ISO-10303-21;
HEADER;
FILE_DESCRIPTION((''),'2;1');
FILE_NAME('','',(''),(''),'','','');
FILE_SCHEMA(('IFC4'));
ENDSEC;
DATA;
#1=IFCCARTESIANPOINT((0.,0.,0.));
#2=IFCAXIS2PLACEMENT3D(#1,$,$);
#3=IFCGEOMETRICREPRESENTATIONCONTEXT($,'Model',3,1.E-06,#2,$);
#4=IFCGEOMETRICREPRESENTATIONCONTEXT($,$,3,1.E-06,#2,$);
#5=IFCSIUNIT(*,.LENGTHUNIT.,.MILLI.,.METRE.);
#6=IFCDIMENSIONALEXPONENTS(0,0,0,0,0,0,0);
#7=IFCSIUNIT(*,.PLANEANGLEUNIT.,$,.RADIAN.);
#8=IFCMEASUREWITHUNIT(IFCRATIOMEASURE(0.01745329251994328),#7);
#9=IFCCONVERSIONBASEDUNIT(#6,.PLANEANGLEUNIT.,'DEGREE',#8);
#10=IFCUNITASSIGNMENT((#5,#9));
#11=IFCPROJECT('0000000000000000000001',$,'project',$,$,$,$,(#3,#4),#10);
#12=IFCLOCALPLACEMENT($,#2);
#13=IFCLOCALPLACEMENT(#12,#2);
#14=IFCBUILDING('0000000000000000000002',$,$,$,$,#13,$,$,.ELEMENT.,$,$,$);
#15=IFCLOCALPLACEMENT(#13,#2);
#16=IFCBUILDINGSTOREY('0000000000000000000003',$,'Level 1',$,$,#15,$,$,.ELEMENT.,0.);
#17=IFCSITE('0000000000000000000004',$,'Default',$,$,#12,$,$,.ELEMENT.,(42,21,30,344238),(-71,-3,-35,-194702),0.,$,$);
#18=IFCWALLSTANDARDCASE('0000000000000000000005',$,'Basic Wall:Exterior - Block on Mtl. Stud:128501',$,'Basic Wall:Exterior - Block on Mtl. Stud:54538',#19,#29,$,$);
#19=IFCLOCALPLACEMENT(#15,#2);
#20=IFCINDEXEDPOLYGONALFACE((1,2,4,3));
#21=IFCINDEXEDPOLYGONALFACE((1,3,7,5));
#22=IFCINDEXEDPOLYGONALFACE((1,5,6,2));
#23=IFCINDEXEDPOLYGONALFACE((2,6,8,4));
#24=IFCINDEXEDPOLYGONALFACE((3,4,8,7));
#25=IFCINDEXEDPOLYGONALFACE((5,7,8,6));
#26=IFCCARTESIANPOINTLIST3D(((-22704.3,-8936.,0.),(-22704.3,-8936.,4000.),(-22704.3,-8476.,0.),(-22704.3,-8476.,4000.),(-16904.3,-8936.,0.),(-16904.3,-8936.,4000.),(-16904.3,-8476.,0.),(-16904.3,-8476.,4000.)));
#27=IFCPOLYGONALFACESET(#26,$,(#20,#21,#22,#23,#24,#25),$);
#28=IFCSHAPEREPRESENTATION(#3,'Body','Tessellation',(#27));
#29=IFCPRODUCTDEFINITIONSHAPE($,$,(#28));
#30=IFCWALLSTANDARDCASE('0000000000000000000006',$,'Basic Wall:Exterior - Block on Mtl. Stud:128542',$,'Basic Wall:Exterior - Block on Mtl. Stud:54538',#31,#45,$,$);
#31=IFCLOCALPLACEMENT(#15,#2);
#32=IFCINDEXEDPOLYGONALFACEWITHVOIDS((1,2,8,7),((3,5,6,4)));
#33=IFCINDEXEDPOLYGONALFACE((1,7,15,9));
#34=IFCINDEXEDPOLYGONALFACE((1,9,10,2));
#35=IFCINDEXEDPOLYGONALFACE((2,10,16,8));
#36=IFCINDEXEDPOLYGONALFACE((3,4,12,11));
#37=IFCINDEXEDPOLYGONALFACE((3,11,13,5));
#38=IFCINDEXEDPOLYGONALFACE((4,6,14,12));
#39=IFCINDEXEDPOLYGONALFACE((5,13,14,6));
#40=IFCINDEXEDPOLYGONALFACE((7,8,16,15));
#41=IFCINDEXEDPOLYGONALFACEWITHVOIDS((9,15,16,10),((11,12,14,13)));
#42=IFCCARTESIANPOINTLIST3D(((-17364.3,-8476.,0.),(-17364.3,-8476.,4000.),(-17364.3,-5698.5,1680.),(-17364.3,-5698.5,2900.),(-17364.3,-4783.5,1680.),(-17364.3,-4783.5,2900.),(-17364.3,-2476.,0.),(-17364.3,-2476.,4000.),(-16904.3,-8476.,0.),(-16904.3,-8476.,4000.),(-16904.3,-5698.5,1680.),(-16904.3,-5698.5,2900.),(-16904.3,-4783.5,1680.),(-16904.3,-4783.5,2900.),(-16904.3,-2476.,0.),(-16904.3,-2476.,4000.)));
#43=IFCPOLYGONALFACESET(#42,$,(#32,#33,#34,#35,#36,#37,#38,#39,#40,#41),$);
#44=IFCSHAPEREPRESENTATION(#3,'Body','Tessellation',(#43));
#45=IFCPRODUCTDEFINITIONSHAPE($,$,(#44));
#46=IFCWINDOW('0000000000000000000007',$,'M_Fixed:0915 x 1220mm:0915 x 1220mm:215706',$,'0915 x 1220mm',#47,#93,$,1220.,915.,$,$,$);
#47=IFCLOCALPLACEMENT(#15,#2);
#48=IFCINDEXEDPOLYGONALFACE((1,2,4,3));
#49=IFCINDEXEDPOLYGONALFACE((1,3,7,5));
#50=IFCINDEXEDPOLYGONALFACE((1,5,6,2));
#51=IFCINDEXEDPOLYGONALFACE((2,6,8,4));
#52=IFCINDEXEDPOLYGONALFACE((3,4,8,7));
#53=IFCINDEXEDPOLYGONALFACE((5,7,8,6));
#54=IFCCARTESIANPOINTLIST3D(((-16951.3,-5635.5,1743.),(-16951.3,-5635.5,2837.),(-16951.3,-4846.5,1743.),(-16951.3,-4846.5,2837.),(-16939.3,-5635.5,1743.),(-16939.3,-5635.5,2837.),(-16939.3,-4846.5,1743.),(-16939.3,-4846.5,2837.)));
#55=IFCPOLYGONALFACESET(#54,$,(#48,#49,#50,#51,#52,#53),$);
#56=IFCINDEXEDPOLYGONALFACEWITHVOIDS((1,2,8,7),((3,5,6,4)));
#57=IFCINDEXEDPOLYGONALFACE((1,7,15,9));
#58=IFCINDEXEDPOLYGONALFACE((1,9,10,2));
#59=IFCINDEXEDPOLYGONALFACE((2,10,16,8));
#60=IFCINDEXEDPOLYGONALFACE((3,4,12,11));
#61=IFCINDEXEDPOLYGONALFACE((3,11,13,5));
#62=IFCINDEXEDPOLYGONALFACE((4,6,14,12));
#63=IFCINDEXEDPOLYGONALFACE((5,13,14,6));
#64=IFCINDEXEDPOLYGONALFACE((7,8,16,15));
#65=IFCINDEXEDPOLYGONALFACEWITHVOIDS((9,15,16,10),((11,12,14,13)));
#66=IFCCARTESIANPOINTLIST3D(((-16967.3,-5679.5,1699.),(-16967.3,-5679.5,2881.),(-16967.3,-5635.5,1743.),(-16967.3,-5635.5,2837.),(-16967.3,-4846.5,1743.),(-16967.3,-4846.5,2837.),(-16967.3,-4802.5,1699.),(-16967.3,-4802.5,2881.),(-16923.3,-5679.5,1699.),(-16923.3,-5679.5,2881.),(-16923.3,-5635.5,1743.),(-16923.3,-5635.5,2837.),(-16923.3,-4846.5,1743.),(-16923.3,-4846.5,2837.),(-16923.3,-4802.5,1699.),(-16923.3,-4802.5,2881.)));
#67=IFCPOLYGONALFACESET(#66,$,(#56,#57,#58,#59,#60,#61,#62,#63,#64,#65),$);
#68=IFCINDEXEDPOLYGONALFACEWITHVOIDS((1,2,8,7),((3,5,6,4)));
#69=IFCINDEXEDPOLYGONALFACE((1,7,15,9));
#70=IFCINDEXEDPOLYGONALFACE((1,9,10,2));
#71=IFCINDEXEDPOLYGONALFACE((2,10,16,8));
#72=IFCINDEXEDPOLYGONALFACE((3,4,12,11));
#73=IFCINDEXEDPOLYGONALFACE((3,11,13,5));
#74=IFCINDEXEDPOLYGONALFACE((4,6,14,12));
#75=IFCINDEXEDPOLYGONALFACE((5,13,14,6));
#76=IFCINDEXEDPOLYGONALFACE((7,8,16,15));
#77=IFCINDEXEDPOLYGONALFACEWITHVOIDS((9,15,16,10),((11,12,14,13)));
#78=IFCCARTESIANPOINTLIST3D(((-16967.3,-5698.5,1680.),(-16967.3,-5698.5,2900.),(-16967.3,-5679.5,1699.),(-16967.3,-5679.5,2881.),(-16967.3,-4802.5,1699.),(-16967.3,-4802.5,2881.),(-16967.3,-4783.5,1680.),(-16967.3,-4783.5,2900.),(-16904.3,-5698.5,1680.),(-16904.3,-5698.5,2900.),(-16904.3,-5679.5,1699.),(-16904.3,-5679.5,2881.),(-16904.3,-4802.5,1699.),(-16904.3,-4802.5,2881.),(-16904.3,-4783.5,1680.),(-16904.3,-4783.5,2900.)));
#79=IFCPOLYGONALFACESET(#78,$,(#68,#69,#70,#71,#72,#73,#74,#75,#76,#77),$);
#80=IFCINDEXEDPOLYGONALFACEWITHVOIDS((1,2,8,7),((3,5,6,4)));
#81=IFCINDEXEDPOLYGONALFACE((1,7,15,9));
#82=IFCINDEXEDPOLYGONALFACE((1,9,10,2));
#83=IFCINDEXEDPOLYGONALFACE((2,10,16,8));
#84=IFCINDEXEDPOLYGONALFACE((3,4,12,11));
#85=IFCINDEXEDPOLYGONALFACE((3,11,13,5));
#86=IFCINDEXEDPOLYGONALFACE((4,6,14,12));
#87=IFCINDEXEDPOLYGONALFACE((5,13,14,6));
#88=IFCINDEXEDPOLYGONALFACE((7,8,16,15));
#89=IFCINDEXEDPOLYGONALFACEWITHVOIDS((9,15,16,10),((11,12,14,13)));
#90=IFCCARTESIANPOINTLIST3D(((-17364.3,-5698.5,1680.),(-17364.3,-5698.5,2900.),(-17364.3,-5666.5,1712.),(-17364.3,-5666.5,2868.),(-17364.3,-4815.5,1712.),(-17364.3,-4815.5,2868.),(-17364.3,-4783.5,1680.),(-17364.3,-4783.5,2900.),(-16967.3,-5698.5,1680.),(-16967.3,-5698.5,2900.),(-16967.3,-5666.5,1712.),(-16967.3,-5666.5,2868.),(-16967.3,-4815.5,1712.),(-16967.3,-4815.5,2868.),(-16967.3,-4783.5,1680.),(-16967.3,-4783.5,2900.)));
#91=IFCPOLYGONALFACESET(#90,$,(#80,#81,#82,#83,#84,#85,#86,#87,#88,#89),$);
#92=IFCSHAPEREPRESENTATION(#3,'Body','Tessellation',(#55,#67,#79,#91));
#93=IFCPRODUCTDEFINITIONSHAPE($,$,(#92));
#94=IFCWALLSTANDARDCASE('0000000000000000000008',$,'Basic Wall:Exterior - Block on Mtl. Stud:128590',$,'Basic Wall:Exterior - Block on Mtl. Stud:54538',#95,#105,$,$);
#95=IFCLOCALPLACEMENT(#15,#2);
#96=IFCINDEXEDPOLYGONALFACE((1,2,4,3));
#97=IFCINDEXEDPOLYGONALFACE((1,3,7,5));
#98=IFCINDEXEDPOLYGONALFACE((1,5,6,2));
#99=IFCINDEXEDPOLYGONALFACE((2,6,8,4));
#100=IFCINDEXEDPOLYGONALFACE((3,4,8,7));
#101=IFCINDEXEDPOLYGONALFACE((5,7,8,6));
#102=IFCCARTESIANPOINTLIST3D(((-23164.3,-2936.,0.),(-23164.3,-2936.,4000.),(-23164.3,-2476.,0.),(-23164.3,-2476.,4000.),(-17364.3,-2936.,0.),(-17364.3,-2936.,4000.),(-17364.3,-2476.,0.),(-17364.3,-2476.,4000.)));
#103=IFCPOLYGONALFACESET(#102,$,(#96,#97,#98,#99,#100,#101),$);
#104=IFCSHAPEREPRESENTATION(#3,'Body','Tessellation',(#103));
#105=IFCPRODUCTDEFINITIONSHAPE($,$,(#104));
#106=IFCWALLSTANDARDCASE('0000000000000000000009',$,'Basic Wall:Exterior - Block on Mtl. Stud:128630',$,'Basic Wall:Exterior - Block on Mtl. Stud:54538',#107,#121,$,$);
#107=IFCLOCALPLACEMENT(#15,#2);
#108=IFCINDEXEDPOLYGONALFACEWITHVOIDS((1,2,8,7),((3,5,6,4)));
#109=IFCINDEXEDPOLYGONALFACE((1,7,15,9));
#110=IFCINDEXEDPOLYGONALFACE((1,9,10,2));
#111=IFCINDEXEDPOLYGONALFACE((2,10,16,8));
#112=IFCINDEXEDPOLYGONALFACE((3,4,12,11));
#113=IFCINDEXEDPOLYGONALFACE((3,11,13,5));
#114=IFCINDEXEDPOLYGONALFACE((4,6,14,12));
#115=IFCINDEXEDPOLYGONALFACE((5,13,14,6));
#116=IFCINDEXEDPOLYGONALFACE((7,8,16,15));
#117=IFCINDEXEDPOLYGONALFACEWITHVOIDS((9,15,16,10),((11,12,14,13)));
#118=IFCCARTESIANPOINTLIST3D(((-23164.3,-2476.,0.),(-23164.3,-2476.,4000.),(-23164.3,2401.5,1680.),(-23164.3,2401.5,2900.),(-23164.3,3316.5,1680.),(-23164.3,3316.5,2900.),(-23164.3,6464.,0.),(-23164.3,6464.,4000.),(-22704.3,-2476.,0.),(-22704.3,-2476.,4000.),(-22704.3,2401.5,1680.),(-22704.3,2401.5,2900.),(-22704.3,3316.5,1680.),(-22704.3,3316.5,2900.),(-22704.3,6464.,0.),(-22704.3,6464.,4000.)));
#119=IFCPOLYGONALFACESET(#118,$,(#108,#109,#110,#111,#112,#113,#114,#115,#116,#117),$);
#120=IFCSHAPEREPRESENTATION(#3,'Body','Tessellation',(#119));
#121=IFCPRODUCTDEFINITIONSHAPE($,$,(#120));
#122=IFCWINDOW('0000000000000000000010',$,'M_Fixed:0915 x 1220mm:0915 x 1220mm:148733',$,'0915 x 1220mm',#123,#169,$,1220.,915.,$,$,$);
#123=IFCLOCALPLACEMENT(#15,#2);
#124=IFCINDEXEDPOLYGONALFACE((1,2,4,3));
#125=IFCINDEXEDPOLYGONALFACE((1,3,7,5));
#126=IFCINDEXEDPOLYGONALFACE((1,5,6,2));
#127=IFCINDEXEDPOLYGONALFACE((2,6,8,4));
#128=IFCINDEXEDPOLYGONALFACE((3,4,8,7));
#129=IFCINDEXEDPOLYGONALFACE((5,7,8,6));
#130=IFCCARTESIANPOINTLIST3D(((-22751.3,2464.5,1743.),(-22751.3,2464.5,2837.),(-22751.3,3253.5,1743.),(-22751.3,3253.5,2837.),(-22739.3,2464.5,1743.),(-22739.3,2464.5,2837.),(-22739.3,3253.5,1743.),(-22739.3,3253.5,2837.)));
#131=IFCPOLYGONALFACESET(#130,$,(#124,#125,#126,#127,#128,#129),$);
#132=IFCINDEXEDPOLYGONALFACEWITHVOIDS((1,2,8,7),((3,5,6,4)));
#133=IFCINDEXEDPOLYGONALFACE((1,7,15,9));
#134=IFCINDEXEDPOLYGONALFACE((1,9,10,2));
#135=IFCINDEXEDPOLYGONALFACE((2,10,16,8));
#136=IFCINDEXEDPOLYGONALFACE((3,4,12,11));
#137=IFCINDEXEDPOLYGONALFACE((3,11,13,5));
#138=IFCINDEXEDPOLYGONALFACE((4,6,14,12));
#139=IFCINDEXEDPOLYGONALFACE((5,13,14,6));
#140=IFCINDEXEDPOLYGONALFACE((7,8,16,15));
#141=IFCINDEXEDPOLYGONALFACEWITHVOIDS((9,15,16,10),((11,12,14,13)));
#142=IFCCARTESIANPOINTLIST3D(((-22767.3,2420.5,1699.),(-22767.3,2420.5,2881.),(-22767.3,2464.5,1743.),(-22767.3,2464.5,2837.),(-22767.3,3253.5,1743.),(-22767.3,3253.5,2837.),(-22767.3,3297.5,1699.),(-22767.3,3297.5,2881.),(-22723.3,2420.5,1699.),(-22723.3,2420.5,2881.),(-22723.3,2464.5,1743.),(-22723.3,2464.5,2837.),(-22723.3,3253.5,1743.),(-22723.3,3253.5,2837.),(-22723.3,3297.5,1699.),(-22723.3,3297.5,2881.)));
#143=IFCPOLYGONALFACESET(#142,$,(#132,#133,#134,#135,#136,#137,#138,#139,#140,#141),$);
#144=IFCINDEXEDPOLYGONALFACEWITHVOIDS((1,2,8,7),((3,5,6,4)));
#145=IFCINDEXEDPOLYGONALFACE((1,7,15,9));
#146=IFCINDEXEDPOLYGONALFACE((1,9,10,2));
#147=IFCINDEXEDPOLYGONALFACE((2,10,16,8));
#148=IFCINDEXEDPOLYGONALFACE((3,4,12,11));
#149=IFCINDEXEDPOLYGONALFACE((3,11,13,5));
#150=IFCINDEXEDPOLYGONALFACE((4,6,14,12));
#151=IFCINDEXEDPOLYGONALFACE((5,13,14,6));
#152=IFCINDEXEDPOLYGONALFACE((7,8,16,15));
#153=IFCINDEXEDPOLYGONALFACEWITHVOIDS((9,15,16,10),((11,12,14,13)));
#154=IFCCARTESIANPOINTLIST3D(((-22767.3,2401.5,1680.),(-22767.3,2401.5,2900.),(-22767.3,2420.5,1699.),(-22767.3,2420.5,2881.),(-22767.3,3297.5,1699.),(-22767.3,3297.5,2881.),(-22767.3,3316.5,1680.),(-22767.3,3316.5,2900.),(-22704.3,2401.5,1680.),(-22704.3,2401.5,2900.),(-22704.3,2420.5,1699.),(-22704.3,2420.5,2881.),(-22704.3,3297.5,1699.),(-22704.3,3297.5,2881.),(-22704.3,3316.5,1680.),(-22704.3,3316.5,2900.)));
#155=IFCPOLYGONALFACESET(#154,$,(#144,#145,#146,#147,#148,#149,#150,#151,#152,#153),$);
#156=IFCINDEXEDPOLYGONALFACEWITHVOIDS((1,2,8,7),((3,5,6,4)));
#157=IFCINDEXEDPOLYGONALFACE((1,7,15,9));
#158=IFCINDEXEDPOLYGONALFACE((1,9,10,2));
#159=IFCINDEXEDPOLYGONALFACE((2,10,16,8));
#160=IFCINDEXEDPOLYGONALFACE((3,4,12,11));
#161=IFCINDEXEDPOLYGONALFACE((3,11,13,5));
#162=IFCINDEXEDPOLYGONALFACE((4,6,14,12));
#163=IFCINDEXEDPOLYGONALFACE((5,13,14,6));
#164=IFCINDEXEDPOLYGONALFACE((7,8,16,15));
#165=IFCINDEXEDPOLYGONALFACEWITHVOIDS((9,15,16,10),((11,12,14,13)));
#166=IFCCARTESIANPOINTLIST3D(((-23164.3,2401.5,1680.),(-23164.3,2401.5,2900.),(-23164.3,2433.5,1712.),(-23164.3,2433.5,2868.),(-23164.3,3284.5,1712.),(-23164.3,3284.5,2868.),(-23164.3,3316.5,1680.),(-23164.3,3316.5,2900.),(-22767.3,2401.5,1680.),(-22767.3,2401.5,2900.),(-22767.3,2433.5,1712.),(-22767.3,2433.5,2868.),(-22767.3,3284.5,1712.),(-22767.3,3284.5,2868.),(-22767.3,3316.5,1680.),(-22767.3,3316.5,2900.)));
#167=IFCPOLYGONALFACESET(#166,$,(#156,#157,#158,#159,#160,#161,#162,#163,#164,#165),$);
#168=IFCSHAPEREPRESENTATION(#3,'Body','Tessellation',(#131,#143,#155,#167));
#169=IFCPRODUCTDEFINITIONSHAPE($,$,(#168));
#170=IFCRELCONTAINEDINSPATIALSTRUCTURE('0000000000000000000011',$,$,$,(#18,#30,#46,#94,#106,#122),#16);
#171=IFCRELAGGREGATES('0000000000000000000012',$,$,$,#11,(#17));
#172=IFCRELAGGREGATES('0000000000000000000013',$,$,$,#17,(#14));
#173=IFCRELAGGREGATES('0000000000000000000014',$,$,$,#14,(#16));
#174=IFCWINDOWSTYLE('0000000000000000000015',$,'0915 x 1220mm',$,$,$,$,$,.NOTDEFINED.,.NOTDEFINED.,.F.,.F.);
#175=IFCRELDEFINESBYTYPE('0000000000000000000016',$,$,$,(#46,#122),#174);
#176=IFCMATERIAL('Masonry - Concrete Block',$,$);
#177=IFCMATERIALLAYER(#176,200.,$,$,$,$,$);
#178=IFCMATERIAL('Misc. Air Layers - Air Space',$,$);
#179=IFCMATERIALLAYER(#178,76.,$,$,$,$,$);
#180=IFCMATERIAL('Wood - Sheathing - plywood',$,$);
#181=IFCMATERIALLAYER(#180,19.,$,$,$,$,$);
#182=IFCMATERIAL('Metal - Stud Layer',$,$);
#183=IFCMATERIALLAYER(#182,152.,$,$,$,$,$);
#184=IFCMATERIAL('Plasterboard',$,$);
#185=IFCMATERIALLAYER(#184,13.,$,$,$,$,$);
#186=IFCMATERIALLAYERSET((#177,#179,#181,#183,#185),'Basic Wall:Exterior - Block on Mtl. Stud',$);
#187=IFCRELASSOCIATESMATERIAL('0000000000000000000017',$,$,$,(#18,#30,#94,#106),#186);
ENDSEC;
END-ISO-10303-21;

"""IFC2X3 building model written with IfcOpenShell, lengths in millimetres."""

from ifc_helpers import new_model, entity, si_unit, converted_unit, frame, frame_2d, origin, origin_2d_with_axis, place, context, project, spatial, polyline, rectangle, outline, extrude, source, transform, mapped, material, layer, layer_set, layer_usage, type_object, type_shapes, element, fill, save


model = new_model("IFC2X3")

# Units and contexts
model_context = context("Model", 3, precision=1e-06, world=origin())
context_of_model = context(None, 3, precision=1e-06, world=origin())
ifc_project = project(units=[si_unit("LENGTHUNIT", "METRE", prefix="MILLI"), converted_unit("PLANEANGLEUNIT", "DEGREE", entity("IfcRatioMeasure", 0.01745329251994328), si_unit("PLANEANGLEUNIT", "RADIAN"), dimensions=[0, 0, 0, 0, 0, 0, 0])], contexts=[model_context, context_of_model])

# Site, building, storey
site_placement = place(None, origin())
site = spatial("IfcSite", under=ifc_project, at=site_placement, Name="Default", CompositionType="ELEMENT", RefLatitude=(42, 21, 30, 344238), RefLongitude=(-71, -3, -35, -194702), RefElevation=0.0)
building_placement = place(site_placement, origin())
building = spatial("IfcBuilding", under=site, at=building_placement, CompositionType="ELEMENT")
storey_placement = place(building_placement, origin())
storey = spatial("IfcBuildingStorey", under=building, at=storey_placement, Name="Level 1", CompositionType="ELEMENT", Elevation=0.0)

# Shared definitions
ifc_material_1 = material(Name="Masonry - Concrete Block")
ifc_layer_1 = layer(ifc_material_1, 200.0)
ifc_material_2 = material(Name="Misc. Air Layers - Air Space")
ifc_layer_2 = layer(ifc_material_2, 76.0)
ifc_material_3 = material(Name="Wood - Sheathing - plywood")
ifc_layer_3 = layer(ifc_material_3, 19.0)
ifc_material_4 = material(Name="Metal - Stud Layer")
ifc_layer_4 = layer(ifc_material_4, 152.0)
ifc_material_5 = material(Name="Plasterboard")
ifc_layer_5 = layer(ifc_material_5, 13.0)
ifc_layer_set_1 = layer_set([ifc_layer_1, ifc_layer_2, ifc_layer_3, ifc_layer_4, ifc_layer_5], Name="Basic Wall:Exterior - Block on Mtl. Stud")

# Shared definitions
window_style = type_object("IfcWindowStyle", Name="0915 x 1220mm", ConstructionType="NOTDEFINED", OperationType="NOTDEFINED", ParameterTakesPrecedence=False, Sizeable=False)
shared_shape_1 = source(origin(), model_context, "Body", "SweptSolid", [
    extrude(rectangle(XDim=12.0, YDim=789.0, at=origin_2d_with_axis()), frame((457.5, 419.0, 63.0), z_axis=(0.0, 0.0, 1.0), x_axis=(0.0, -1.0, 0.0)), (0.0, 0.0, 1.0), 1094.0),
    extrude(outline(polyline([(-438.5, -591.0), (438.5, -591.0), (438.5, 591.0), (-438.5, 591.0), (-438.5, -591.0)]), holes=[polyline([(-394.5, -547.0), (-394.5, 547.0), (394.5, 547.0), (394.5, -547.0), (-394.5, -547.0)])]), frame((457.5, 397.0, 610.0), z_axis=(0.0, 1.0, 0.0), x_axis=(1.0, 0.0, 0.0)), (0.0, 0.0, 1.0), 44.0),
    extrude(outline(polyline([(-457.5, -610.0), (457.5, -610.0), (457.5, 610.0), (-457.5, 610.0), (-457.5, -610.0)]), holes=[polyline([(-438.5, -591.0), (-438.5, 591.0), (438.5, 591.0), (438.5, -591.0), (-438.5, -591.0)])]), frame((457.5, 397.0, 610.0), z_axis=(0.0, 1.0, 0.0), x_axis=(1.0, 0.0, 0.0)), (0.0, 0.0, 1.0), 63.0),
    extrude(outline(polyline([(-457.5, -610.0), (457.5, -610.0), (457.5, 610.0), (-457.5, 610.0), (-457.5, -610.0)]), holes=[polyline([(-425.5, -578.0), (-425.5, 578.0), (425.5, 578.0), (425.5, -578.0), (-425.5, -578.0)])]), frame((457.5, 0.0, 610.0), z_axis=(0.0, 1.0, 0.0), x_axis=(1.0, 0.0, 0.0)), (0.0, 0.0, 1.0), 397.0),
])
type_shapes(window_style, [shared_shape_1])

# Wall
ifc_layer_usage_1 = layer_usage(ifc_layer_set_1, "AXIS2", "NEGATIVE", 230.0)
wall_1_placement = place(storey_placement, frame((-22704.3, -8706.0, 0.0)))
element("IfcWallStandardCase", 1, at=wall_1_placement, inside=storey, material=ifc_layer_usage_1, Name="Basic Wall:Exterior - Block on Mtl. Stud:128501", ObjectType="Basic Wall:Exterior - Block on Mtl. Stud:54538", context=model_context, shape_type="SweptSolid", body=[
    extrude(rectangle(XDim=5800.0, YDim=460.0, at=frame_2d((2900.0, 0.0), x_axis=(-1.0, 0.0))), origin(), (0.0, 0.0, 1.0), 4000.0),
])

# Wall, opening, window
ifc_layer_usage_2 = layer_usage(ifc_layer_set_1, "AXIS2", "NEGATIVE", 230.0)
wall_2_placement = place(storey_placement, frame((-17134.3, -8476.0, 0.0), z_axis=(0.0, 0.0, 1.0), x_axis=(0.0, 1.0, 0.0)))
wall_2 = element("IfcWallStandardCase", 2, at=wall_2_placement, inside=storey, material=ifc_layer_usage_2, Name="Basic Wall:Exterior - Block on Mtl. Stud:128542", ObjectType="Basic Wall:Exterior - Block on Mtl. Stud:54538", context=model_context, shape_type="SweptSolid", body=[
    extrude(rectangle(XDim=6000.0, YDim=460.0, at=frame_2d((3000.0, 0.0), x_axis=(-1.0, 0.0))), origin(), (0.0, 0.0, 1.0), 4000.0),
])
opening_1_placement = place(wall_2_placement, frame((2777.5, -230.0, 1680.0)))
opening_1 = element("IfcOpeningElement", 3, at=opening_1_placement, cuts=wall_2, ObjectType="Opening", context=model_context, shape_type="SweptSolid", body=[
    extrude(rectangle(XDim=1220.0, YDim=915.0, at=frame_2d((610.0, 457.5), x_axis=(1.0, 0.0))), frame((0.0, 0.0, 0.0), z_axis=(0.0, 1.0, 0.0), x_axis=(0.0, 0.0, 1.0)), (0.0, 0.0, 1.0), 460.0),
])
window_1_placement = place(opening_1_placement, frame((915.0, 460.0, 0.0), z_axis=(0.0, 0.0, 1.0), x_axis=(-1.0, 0.0, 0.0)))
window_1 = element("IfcWindow", 4, at=window_1_placement, inside=storey, type_object=window_style, Name="M_Fixed:0915 x 1220mm:0915 x 1220mm:215706", ObjectType="0915 x 1220mm", OverallHeight=1220.0, OverallWidth=915.0, context=model_context, shape_type="MappedRepresentation", body=[
    mapped(shared_shape_1, transform((0.0, 0.0, 0.0), scale=1.0)),
])
fill(opening_1, window_1)

# Wall
ifc_layer_usage_3 = layer_usage(ifc_layer_set_1, "AXIS2", "NEGATIVE", 230.0)
wall_3_placement = place(storey_placement, frame((-17364.3, -2706.0, 0.0), z_axis=(0.0, 0.0, 1.0), x_axis=(-1.0, 0.0, 0.0)))
element("IfcWallStandardCase", 5, at=wall_3_placement, inside=storey, material=ifc_layer_usage_3, Name="Basic Wall:Exterior - Block on Mtl. Stud:128590", ObjectType="Basic Wall:Exterior - Block on Mtl. Stud:54538", context=model_context, shape_type="SweptSolid", body=[
    extrude(rectangle(XDim=5800.0, YDim=460.0, at=frame_2d((2900.0, 0.0), x_axis=(-1.0, 0.0))), origin(), (0.0, 0.0, 1.0), 4000.0),
])

# Wall, opening, window
ifc_layer_usage_4 = layer_usage(ifc_layer_set_1, "AXIS2", "NEGATIVE", 230.0)
wall_4_placement = place(storey_placement, frame((-22934.3, -2476.0, 0.0), z_axis=(0.0, 0.0, 1.0), x_axis=(0.0, 1.0, 0.0)))
wall_4 = element("IfcWallStandardCase", 6, at=wall_4_placement, inside=storey, material=ifc_layer_usage_4, Name="Basic Wall:Exterior - Block on Mtl. Stud:128630", ObjectType="Basic Wall:Exterior - Block on Mtl. Stud:54538", context=model_context, shape_type="SweptSolid", body=[
    extrude(rectangle(XDim=8940.0, YDim=460.0, at=frame_2d((4470.0, 0.0), x_axis=(-1.0, 0.0))), origin(), (0.0, 0.0, 1.0), 4000.0),
])
opening_2_placement = place(wall_4_placement, frame((4877.5, -230.0, 1680.0)))
opening_2 = element("IfcOpeningElement", 7, at=opening_2_placement, cuts=wall_4, ObjectType="Opening", context=model_context, shape_type="SweptSolid", body=[
    extrude(rectangle(XDim=1220.0, YDim=915.0, at=frame_2d((610.0, 457.5), x_axis=(1.0, 0.0))), frame((0.0, 0.0, 0.0), z_axis=(0.0, 1.0, 0.0), x_axis=(0.0, 0.0, 1.0)), (0.0, 0.0, 1.0), 460.0),
])
window_2_placement = place(opening_2_placement, frame((915.0, 460.0, 0.0), z_axis=(0.0, 0.0, 1.0), x_axis=(-1.0, 0.0, 0.0)))
window_2 = element("IfcWindow", 8, at=window_2_placement, inside=storey, type_object=window_style, Name="M_Fixed:0915 x 1220mm:0915 x 1220mm:148733", ObjectType="0915 x 1220mm", OverallHeight=1220.0, OverallWidth=915.0, context=model_context, shape_type="MappedRepresentation", body=[
    mapped(shared_shape_1, transform((0.0, 0.0, 0.0), scale=1.0)),
])
fill(opening_2, window_2)

save(model, "model.ifc")
